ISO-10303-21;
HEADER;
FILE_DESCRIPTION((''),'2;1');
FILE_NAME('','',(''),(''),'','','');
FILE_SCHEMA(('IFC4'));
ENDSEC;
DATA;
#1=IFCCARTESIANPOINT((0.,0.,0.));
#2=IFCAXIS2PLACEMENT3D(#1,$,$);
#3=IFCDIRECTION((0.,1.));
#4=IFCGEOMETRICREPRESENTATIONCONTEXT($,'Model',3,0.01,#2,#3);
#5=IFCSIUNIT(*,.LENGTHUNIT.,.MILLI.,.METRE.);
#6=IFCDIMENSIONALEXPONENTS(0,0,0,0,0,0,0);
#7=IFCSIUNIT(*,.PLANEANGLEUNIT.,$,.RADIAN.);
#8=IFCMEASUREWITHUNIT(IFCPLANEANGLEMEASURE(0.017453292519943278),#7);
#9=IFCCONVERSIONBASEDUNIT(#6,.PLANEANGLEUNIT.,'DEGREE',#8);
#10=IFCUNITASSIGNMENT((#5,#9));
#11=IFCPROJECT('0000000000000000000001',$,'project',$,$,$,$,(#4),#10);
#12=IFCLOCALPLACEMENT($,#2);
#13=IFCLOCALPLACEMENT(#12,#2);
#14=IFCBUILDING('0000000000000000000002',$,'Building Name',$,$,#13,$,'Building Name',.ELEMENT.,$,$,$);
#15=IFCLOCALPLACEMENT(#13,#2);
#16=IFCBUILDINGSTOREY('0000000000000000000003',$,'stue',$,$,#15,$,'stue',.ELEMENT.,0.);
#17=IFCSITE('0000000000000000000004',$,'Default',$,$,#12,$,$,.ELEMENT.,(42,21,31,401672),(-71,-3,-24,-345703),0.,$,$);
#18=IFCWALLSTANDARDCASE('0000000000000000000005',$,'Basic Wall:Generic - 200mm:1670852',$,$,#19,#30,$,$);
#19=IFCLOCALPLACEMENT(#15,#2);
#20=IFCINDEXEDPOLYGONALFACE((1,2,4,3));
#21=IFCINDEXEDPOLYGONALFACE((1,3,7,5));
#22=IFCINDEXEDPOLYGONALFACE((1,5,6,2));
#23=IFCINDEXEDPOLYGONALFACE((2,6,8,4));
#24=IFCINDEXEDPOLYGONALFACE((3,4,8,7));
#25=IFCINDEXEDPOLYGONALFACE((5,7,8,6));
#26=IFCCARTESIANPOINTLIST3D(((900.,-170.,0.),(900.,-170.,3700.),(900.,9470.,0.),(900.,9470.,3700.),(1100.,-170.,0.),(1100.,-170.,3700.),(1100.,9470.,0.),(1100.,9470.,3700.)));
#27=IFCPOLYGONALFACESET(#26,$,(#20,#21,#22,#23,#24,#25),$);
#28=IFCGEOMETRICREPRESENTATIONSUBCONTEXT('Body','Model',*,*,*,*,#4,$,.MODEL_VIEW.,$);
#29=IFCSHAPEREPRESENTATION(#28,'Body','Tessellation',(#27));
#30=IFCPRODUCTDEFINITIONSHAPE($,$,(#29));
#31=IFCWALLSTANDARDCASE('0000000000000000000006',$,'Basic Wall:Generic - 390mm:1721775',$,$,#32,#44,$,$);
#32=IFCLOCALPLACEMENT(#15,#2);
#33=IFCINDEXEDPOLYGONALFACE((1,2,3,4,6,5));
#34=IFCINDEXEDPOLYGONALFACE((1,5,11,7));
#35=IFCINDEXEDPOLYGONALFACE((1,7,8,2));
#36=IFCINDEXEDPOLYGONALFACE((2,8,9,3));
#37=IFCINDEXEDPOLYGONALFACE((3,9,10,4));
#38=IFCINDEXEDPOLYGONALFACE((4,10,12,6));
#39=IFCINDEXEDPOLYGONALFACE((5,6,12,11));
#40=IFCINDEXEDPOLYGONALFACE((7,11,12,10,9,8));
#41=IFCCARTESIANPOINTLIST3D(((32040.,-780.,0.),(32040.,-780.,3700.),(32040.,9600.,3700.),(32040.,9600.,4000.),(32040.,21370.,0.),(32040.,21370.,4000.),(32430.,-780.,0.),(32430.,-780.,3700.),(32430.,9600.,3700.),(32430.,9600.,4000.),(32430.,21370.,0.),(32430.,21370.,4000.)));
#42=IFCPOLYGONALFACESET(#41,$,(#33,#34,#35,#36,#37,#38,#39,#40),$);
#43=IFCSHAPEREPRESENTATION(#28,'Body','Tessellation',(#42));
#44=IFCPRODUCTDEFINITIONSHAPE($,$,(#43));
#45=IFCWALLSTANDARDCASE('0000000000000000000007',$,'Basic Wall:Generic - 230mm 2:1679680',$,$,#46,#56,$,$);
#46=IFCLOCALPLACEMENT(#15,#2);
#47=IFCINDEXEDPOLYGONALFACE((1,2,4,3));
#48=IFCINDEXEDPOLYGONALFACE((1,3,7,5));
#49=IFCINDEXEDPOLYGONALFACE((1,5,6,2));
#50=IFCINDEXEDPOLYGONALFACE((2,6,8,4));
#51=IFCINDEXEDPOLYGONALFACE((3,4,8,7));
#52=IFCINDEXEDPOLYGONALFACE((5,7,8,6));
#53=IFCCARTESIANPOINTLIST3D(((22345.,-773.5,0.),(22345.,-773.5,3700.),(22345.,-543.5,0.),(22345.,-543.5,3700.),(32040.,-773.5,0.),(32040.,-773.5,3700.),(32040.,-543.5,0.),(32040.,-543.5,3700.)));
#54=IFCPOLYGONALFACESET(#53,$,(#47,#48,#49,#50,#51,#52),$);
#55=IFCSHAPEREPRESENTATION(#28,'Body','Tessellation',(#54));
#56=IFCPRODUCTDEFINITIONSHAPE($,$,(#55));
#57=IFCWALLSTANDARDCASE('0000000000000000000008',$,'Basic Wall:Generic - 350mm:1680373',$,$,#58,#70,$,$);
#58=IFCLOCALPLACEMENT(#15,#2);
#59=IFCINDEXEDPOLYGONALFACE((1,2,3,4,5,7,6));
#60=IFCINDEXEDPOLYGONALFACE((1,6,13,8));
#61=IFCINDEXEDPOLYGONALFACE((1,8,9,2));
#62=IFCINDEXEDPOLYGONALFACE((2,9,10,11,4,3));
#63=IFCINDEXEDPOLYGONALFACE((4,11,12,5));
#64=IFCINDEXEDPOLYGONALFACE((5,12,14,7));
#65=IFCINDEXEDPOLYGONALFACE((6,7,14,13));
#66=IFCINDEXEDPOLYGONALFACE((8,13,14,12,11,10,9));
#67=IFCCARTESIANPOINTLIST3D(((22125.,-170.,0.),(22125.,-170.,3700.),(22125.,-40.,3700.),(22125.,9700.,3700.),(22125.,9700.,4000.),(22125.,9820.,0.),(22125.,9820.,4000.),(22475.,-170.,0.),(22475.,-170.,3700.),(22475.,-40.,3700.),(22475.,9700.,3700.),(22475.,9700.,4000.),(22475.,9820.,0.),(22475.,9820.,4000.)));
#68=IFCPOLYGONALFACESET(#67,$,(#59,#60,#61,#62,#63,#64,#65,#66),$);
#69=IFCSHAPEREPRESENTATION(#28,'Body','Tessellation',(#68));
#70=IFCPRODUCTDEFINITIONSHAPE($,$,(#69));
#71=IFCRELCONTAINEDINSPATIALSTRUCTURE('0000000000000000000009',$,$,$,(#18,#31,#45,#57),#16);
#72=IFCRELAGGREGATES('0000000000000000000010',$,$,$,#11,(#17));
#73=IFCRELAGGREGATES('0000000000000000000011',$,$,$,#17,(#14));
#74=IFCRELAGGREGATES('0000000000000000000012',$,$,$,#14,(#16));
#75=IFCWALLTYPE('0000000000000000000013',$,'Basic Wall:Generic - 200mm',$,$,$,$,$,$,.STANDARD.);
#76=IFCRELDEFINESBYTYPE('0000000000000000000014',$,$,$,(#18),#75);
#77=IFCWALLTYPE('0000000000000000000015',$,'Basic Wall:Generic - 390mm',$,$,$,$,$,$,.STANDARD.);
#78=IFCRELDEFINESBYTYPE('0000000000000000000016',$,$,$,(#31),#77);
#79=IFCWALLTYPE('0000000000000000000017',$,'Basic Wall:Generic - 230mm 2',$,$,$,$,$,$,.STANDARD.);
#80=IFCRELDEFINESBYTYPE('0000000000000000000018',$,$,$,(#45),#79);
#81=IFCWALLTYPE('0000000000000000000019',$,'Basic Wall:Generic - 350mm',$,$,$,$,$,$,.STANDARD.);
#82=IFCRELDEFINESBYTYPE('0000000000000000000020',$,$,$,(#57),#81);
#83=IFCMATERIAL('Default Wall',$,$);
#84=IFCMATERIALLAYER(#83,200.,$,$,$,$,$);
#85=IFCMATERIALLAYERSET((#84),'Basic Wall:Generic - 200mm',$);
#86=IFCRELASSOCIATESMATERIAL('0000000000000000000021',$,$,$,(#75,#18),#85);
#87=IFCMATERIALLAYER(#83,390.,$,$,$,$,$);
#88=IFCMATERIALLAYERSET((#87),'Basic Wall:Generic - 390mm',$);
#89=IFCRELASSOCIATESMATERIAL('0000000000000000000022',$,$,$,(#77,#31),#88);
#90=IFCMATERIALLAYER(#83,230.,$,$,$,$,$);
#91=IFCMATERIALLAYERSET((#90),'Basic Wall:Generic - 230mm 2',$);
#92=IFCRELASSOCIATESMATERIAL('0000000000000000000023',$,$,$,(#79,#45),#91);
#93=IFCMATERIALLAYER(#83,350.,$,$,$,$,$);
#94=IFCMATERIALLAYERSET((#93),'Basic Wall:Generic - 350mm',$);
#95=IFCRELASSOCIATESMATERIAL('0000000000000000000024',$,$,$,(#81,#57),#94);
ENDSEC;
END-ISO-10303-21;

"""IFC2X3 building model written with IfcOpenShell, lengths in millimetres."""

from ifc_helpers import new_model, entity, si_unit, converted_unit, direction, frame, frame_2d, origin, place, context, subcontext, project, spatial, polyline, rectangle, extrude, clip, bounded_halfspace, material, layer, layer_set, layer_usage, type_object, element, save


model = new_model("IFC2X3")

# Units and contexts
model_context = context("Model", 3, precision=0.01, world=origin(), true_north=direction((0.0, 1.0)))
body_context = subcontext(model_context, "Body", "Model", "MODEL_VIEW")
ifc_project = project(units=[si_unit("LENGTHUNIT", "METRE", prefix="MILLI"), converted_unit("PLANEANGLEUNIT", "DEGREE", entity("IfcPlaneAngleMeasure", 0.017453292519943278), si_unit("PLANEANGLEUNIT", "RADIAN"), dimensions=[0, 0, 0, 0, 0, 0, 0])], contexts=[model_context])

# Site, building, storey
site_placement = place(None, origin())
site = spatial("IfcSite", under=ifc_project, at=site_placement, Name="Default", CompositionType="ELEMENT", RefLatitude=(42, 21, 31, 401672), RefLongitude=(-71, -3, -24, -345703), RefElevation=0.0)
building_placement = place(site_placement, origin())
building = spatial("IfcBuilding", under=site, at=building_placement, Name="Building Name", LongName="Building Name", CompositionType="ELEMENT")
storey_placement = place(building_placement, origin())
storey = spatial("IfcBuildingStorey", under=building, at=storey_placement, Name="stue", LongName="stue", CompositionType="ELEMENT", Elevation=0.0)

# Walls
ifc_material_1 = material(Name="Default Wall")
ifc_layer_1 = layer(ifc_material_1, 200.0)
ifc_layer_set_1 = layer_set([ifc_layer_1], Name="Basic Wall:Generic - 200mm")
ifc_layer_usage_1 = layer_usage(ifc_layer_set_1, "AXIS2", "NEGATIVE", 100.0)
wall_type_1 = type_object("IfcWallType", Name="Basic Wall:Generic - 200mm", PredefinedType="STANDARD", material=ifc_layer_set_1)
wall_1_placement = place(storey_placement, frame((1000.0, 9470.0, 0.0), z_axis=(0.0, 0.0, 1.0), x_axis=(0.0, -1.0, 0.0)))
element("IfcWallStandardCase", 1, at=wall_1_placement, inside=storey, type_object=wall_type_1, material=ifc_layer_usage_1, Name="Basic Wall:Generic - 200mm:1670852", context=body_context, shape_type="Clipping", body=[
    clip(clip(extrude(rectangle(XDim=9640.0, YDim=200.0, at=frame_2d((4820.0, 0.0), x_axis=(-1.0, 0.0))), origin(), (0.0, 0.0, 1.0), 3700.0), bounded_halfspace(frame((0.0, -100.0, 3700.0), z_axis=(0.0, 0.0, -1.0), x_axis=(1.0, 0.0, 0.0)), True, frame((0.0, -100.0, 3700.0)), polyline([(0.0, 0.0), (9510.0, 0.0), (9510.0, 200.0), (0.0, 200.0), (0.0, 0.0)]))), bounded_halfspace(frame((9510.0, -100.0, 3700.0), z_axis=(0.0, 0.0, -1.0), x_axis=(1.0, 0.0, 0.0)), True, frame((9510.0, -100.0, 3700.0)), polyline([(0.0, 0.0), (130.0, 0.0), (130.0, 200.0), (0.0, 200.0), (0.0, 0.0)]))),
])
ifc_layer_2 = layer(ifc_material_1, 390.0)
ifc_layer_set_2 = layer_set([ifc_layer_2], Name="Basic Wall:Generic - 390mm")
ifc_layer_usage_2 = layer_usage(ifc_layer_set_2, "AXIS2", "NEGATIVE", 195.0)
wall_type_2 = type_object("IfcWallType", Name="Basic Wall:Generic - 390mm", PredefinedType="STANDARD", material=ifc_layer_set_2)
wall_2_placement = place(storey_placement, frame((32235.0, -780.0, 0.0), z_axis=(0.0, 0.0, 1.0), x_axis=(0.0, 1.0, 0.0)))
element("IfcWallStandardCase", 2, at=wall_2_placement, inside=storey, type_object=wall_type_2, material=ifc_layer_usage_2, Name="Basic Wall:Generic - 390mm:1721775", context=body_context, shape_type="Clipping", body=[
    clip(extrude(rectangle(XDim=22150.0, YDim=390.0, at=frame_2d((11075.0, 0.0), x_axis=(-1.0, 0.0))), origin(), (0.0, 0.0, 1.0), 4000.0), bounded_halfspace(frame((0.0, -195.0, 3700.0), z_axis=(0.0, 0.0, -1.0), x_axis=(1.0, 0.0, 0.0)), True, frame((0.0, -195.0, 3700.0)), polyline([(0.0, 0.0), (10380.0, 0.0), (10380.0, 390.0), (236.5, 390.0), (6.5, 390.0), (0.0, 390.0), (0.0, 0.0)]))),
])
ifc_layer_3 = layer(ifc_material_1, 230.0)
ifc_layer_set_3 = layer_set([ifc_layer_3], Name="Basic Wall:Generic - 230mm 2")
ifc_layer_usage_3 = layer_usage(ifc_layer_set_3, "AXIS2", "NEGATIVE", 115.0)
wall_type_3 = type_object("IfcWallType", Name="Basic Wall:Generic - 230mm 2", PredefinedType="STANDARD", material=ifc_layer_set_3)
wall_3_placement = place(storey_placement, frame((22345.0, -658.5, 0.0)))
element("IfcWallStandardCase", 3, at=wall_3_placement, inside=storey, type_object=wall_type_3, material=ifc_layer_usage_3, Name="Basic Wall:Generic - 230mm 2:1679680", context=body_context, shape_type="Clipping", body=[
    clip(clip(extrude(rectangle(XDim=9695.0, YDim=230.0, at=frame_2d((4847.5, 0.0), x_axis=(-1.0, 0.0))), origin(), (0.0, 0.0, 1.0), 3700.0), bounded_halfspace(frame((150.0, -115.0, 3700.0), z_axis=(0.0, 0.0, -1.0), x_axis=(0.0, 1.0, 0.0)), True, frame((150.0, -115.0, 3700.0)), polyline([(0.0, 0.0), (9545.0, 0.0), (9545.0, 230.0), (0.0, 230.0), (0.0, 0.0)]))), bounded_halfspace(frame((0.0, -115.0, 3700.0), z_axis=(0.0, 0.0, -1.0), x_axis=(0.0, -1.0, 0.0)), True, frame((0.0, -115.0, 3700.0)), polyline([(0.0, 0.0), (150.0, 0.0), (150.0, 230.0), (0.0, 230.0), (0.0, 0.0)]))),
])
ifc_layer_4 = layer(ifc_material_1, 350.0)
ifc_layer_set_4 = layer_set([ifc_layer_4], Name="Basic Wall:Generic - 350mm")
ifc_layer_usage_4 = layer_usage(ifc_layer_set_4, "AXIS2", "NEGATIVE", 175.0)
wall_type_4 = type_object("IfcWallType", Name="Basic Wall:Generic - 350mm", PredefinedType="STANDARD", material=ifc_layer_set_4)
wall_4_placement = place(storey_placement, frame((22300.0, 9820.0, 0.0), z_axis=(0.0, 0.0, 1.0), x_axis=(0.0, -1.0, 0.0)))
element("IfcWallStandardCase", 4, at=wall_4_placement, inside=storey, type_object=wall_type_4, material=ifc_layer_usage_4, Name="Basic Wall:Generic - 350mm:1680373", context=body_context, shape_type="Clipping", body=[
    clip(clip(extrude(rectangle(XDim=9990.0, YDim=350.0, at=frame_2d((4995.0, 0.0), x_axis=(-1.0, 0.0))), origin(), (0.0, 0.0, 1.0), 4000.0), bounded_halfspace(frame((120.0, -175.0, 3700.0), z_axis=(0.0, 0.0, -1.0), x_axis=(1.0, 0.0, 0.0)), True, frame((120.0, -175.0, 3700.0)), polyline([(0.0, 0.0), (9740.0, 0.0), (9740.0, 350.0), (0.0, 350.0), (0.0, 0.0)]))), bounded_halfspace(frame((9860.0, -175.0, 3700.0), z_axis=(0.0, 0.0, -1.0), x_axis=(1.0, 0.0, 0.0)), True, frame((9860.0, -175.0, 3700.0)), polyline([(0.0, 0.0), (130.0, 0.0), (130.0, 350.0), (0.0, 350.0), (0.0, 0.0)]))),
])

save(model, "model.ifc")
